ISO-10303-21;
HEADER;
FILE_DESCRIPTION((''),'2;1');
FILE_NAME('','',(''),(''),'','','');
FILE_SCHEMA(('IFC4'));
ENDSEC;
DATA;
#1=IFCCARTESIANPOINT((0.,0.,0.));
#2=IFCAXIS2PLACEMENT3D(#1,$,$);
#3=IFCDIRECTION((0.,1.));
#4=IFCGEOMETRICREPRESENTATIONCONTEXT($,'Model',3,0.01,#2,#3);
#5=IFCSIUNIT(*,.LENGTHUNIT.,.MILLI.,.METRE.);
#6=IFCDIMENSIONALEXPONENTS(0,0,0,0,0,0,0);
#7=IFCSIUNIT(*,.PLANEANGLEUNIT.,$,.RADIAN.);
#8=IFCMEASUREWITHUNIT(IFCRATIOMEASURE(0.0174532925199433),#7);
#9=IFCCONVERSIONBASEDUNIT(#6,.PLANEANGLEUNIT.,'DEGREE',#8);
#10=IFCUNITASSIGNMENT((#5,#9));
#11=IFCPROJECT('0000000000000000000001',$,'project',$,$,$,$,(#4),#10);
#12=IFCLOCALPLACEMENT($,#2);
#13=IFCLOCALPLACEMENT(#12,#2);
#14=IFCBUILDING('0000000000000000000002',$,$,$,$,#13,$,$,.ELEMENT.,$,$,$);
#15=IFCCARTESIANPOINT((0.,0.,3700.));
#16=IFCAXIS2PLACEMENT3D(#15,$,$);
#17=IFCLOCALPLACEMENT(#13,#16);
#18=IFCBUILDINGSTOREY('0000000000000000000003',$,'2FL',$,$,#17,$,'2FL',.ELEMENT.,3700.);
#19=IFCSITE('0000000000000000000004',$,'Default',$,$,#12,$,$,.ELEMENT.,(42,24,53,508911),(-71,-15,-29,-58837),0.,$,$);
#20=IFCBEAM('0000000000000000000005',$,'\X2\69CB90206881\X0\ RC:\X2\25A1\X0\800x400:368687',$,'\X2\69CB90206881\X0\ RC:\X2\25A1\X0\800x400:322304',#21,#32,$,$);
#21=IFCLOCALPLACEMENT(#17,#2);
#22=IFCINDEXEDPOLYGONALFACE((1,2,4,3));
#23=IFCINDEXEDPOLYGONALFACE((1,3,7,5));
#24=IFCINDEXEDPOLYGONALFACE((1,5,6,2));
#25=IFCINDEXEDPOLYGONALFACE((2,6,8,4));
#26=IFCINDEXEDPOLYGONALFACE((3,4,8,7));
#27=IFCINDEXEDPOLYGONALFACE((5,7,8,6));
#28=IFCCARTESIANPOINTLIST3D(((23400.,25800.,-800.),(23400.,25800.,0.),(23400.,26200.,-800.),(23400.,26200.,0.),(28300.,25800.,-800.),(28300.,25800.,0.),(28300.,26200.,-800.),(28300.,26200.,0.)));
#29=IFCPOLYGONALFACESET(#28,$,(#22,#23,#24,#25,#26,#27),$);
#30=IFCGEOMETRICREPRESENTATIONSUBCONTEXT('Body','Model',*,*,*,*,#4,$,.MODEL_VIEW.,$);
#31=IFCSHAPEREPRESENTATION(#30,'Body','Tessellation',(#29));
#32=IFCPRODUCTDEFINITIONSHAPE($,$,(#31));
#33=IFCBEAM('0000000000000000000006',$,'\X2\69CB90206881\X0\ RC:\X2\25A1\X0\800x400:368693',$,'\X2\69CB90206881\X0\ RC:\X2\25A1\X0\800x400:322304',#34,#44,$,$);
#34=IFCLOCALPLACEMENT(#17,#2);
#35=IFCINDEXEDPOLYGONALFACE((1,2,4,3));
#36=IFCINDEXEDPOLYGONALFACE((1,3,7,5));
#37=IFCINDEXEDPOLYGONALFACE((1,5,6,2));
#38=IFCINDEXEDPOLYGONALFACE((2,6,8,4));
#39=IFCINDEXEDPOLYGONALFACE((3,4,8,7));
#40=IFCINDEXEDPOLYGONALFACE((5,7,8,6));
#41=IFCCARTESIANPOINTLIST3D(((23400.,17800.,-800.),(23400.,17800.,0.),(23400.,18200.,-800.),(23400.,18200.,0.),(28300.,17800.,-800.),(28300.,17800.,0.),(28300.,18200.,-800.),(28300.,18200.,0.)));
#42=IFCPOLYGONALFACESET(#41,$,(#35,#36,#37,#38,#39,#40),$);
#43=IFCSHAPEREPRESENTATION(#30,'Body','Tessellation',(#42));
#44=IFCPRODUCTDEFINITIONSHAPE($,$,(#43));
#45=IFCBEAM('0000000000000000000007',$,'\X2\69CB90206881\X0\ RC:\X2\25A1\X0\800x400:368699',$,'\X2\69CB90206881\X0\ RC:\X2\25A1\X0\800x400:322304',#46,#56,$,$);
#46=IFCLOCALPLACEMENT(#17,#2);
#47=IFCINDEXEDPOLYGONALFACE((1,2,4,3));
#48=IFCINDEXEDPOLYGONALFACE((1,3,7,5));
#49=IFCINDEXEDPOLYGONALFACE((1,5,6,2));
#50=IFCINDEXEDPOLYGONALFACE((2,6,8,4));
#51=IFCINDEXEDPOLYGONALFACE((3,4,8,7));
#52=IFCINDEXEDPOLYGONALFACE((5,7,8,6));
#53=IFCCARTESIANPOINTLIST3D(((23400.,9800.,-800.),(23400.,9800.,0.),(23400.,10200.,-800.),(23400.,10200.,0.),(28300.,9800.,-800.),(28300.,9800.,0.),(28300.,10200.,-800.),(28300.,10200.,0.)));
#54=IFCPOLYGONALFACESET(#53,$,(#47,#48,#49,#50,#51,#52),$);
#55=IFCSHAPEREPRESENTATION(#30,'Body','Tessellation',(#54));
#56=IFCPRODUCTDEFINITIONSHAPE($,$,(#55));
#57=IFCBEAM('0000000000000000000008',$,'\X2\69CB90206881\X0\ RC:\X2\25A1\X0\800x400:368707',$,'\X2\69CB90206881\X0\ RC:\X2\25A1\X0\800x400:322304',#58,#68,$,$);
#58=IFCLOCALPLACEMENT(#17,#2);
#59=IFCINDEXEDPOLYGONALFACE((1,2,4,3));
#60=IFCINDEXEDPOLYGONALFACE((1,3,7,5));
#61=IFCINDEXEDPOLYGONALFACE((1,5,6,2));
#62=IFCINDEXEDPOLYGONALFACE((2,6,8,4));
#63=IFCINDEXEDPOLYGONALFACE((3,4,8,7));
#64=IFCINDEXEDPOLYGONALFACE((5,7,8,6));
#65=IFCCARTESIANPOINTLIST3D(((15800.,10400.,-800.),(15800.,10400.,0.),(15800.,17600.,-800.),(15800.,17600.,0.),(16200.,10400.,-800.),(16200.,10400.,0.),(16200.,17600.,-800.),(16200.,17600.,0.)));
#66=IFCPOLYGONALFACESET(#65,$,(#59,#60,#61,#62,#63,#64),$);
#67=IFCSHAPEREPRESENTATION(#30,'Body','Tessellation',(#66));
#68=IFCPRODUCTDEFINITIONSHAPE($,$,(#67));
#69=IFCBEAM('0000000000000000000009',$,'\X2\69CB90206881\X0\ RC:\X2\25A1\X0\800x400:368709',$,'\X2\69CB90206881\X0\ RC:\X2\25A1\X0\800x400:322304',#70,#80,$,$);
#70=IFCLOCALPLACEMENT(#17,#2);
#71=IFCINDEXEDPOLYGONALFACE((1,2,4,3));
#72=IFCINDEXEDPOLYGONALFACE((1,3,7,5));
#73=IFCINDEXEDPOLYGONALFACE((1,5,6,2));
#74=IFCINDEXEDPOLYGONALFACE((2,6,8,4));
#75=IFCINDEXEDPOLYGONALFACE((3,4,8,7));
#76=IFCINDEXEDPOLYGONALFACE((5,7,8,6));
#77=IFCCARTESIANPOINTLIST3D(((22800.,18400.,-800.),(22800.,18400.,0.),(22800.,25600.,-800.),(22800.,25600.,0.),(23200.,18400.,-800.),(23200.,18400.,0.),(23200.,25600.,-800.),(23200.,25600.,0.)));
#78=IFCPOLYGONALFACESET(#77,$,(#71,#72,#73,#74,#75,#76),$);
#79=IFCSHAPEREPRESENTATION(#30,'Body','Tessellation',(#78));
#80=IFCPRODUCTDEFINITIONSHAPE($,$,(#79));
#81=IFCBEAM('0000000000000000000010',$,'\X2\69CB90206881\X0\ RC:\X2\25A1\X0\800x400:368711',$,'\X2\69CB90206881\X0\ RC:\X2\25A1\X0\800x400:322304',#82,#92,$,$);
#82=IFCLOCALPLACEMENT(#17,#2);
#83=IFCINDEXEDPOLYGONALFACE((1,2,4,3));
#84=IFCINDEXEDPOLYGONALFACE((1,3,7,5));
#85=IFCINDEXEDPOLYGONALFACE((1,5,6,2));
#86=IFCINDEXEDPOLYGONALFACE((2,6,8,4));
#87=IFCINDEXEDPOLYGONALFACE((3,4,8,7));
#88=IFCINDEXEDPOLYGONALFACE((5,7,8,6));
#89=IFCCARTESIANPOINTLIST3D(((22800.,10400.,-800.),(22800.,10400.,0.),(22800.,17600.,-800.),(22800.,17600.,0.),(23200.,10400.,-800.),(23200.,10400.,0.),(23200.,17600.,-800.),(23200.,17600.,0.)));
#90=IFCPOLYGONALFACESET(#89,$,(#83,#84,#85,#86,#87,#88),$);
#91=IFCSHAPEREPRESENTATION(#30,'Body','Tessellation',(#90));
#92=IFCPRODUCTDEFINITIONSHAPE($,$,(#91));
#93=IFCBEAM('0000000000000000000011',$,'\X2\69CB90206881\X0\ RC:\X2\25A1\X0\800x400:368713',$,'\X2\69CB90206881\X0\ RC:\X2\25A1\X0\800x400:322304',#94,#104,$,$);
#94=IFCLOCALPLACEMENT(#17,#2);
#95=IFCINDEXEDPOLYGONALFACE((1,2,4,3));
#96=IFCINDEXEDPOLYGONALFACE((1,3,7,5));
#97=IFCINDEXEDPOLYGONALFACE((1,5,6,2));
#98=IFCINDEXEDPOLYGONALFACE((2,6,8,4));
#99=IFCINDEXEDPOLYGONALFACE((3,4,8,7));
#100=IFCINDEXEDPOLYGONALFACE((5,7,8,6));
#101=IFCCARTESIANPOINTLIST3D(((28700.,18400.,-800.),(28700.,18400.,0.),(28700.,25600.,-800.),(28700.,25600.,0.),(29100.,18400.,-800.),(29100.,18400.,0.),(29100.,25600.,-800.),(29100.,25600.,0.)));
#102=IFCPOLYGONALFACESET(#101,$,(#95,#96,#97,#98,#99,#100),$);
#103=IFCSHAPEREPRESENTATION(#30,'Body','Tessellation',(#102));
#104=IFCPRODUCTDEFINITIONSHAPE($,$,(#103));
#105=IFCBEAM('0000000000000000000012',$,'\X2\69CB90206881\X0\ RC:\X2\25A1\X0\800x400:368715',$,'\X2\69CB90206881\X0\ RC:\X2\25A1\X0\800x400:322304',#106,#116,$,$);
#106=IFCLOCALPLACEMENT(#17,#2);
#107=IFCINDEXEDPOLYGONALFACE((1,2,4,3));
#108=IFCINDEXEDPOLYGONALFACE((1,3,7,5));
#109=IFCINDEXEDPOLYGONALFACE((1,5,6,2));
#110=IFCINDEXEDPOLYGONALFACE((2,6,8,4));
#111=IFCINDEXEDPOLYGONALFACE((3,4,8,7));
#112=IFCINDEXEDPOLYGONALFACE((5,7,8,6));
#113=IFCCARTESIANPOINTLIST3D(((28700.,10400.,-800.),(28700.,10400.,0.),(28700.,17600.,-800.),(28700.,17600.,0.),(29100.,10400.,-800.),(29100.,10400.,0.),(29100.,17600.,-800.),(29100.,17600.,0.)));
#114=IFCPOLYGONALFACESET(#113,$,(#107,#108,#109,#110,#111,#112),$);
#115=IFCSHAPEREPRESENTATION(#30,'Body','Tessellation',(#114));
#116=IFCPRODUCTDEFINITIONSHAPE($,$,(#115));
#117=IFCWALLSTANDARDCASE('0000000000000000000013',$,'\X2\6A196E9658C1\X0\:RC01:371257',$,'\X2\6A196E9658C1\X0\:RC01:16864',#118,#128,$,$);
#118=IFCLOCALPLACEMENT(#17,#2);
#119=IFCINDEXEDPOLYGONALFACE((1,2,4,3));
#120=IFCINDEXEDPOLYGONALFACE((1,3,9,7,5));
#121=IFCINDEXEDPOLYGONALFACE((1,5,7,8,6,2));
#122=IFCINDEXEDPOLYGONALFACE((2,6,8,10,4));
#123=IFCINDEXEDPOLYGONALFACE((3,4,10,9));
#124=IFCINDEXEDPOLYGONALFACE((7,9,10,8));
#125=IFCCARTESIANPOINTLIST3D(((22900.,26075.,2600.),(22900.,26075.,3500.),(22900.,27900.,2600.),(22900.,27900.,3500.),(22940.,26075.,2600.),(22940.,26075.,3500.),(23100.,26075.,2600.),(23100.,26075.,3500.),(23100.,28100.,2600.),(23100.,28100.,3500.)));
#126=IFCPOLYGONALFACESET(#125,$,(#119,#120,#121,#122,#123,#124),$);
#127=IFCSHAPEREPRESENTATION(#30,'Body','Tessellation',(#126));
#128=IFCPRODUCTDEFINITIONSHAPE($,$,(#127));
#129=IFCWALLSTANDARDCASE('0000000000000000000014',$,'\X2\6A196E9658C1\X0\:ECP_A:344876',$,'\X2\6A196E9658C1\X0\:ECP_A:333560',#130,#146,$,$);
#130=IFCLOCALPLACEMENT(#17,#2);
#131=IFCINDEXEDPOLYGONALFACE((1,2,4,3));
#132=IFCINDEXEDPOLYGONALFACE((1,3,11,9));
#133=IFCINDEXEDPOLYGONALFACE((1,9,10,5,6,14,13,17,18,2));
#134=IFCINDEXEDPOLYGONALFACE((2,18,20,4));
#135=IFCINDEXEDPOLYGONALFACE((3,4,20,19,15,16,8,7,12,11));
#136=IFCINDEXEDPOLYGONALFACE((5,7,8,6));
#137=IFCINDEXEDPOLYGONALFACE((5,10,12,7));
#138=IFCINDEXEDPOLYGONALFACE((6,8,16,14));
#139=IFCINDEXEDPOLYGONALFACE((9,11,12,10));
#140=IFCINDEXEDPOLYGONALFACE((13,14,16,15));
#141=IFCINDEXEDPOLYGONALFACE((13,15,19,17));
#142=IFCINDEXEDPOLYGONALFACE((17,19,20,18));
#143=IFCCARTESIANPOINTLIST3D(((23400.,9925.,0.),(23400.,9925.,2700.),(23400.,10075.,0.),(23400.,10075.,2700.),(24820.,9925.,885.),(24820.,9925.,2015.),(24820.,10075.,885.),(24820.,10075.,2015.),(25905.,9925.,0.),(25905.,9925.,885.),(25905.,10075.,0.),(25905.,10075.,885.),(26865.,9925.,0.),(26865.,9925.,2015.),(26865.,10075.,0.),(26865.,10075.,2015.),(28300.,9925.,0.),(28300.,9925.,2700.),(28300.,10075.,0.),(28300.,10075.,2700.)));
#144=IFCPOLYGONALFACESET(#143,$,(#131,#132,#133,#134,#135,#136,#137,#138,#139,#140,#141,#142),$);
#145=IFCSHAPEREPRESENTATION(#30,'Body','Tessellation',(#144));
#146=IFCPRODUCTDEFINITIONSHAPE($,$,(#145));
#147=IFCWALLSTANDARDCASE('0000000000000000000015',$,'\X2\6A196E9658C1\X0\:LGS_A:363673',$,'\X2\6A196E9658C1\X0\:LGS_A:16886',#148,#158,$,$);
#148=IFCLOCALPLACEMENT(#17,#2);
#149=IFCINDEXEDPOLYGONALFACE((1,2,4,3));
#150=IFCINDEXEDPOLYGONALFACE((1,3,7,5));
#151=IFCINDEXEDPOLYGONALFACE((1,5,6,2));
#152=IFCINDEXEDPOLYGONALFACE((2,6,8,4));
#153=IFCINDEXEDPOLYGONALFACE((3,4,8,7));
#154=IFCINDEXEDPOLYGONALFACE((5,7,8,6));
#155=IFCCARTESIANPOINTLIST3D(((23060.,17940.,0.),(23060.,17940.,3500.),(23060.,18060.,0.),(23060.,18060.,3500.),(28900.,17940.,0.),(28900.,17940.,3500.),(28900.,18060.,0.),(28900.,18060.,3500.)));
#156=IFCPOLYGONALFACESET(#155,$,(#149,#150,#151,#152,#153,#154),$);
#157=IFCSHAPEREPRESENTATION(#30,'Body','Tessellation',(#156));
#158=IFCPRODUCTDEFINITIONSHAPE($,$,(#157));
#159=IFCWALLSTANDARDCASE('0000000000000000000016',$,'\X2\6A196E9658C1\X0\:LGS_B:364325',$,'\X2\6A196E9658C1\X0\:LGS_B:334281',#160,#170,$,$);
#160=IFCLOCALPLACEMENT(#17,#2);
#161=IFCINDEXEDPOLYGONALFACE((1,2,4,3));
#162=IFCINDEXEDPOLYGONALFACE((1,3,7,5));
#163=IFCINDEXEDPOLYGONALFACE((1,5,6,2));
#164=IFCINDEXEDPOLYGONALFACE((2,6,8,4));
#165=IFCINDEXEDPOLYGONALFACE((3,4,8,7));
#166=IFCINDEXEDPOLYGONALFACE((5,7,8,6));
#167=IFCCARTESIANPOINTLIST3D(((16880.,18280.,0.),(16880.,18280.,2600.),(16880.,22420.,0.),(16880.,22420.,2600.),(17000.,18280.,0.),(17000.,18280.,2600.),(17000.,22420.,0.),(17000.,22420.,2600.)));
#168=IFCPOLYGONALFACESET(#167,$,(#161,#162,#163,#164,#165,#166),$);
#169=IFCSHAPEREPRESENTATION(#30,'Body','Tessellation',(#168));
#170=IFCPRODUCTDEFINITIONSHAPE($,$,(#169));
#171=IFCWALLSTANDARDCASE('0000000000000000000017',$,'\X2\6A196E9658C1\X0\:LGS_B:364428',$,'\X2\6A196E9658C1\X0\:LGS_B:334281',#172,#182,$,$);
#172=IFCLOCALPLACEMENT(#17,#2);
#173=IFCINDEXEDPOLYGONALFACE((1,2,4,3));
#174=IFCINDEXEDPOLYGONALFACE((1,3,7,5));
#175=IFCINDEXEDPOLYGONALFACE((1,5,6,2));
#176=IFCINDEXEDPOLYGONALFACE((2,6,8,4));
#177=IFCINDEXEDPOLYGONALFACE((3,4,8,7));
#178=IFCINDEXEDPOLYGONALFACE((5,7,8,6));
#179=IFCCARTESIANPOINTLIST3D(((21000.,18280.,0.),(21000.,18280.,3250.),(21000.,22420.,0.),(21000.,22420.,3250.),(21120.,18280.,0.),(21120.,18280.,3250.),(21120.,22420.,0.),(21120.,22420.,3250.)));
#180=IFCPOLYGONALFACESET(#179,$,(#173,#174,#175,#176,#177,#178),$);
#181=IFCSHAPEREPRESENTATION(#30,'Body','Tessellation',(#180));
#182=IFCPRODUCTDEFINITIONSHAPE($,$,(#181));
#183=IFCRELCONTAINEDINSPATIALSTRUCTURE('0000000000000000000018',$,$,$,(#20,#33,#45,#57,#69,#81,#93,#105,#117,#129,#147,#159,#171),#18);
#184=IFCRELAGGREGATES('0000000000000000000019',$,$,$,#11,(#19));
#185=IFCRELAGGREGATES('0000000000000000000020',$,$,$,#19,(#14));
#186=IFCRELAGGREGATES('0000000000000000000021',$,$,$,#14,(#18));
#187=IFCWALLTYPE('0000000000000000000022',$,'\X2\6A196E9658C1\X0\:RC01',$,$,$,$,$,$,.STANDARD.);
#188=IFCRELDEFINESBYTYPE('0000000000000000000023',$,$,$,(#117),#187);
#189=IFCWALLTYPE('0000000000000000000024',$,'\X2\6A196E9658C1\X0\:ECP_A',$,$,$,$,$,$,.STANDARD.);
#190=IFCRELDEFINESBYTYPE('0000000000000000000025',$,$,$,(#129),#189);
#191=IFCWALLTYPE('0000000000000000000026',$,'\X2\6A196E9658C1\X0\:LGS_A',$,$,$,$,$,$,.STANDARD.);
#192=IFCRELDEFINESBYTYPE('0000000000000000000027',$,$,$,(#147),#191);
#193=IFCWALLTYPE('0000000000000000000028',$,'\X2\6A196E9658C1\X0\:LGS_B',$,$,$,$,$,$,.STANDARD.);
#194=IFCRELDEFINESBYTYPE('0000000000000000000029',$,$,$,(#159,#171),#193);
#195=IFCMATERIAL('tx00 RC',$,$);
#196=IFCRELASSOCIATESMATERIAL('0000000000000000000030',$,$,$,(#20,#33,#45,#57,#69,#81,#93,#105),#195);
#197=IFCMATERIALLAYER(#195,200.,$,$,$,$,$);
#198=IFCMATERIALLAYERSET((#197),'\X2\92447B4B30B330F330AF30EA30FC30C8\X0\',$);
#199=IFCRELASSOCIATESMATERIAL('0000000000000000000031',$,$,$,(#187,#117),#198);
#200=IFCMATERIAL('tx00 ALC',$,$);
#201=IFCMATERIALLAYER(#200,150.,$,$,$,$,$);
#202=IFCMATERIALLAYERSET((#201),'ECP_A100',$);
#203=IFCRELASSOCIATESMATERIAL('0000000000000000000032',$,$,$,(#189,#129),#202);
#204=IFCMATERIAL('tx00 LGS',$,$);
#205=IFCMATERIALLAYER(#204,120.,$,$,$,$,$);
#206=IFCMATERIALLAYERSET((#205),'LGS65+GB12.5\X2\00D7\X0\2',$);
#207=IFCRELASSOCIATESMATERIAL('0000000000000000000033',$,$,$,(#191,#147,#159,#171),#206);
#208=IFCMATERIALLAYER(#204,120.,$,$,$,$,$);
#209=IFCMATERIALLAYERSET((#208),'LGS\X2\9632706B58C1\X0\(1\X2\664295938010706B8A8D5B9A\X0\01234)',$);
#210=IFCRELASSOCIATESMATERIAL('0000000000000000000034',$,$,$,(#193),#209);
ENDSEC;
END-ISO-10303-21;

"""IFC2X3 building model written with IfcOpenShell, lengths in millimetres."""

from ifc_helpers import new_model, entity, si_unit, converted_unit, direction, frame, frame_2d, origin, place, context, subcontext, project, spatial, polyline, rectangle, outline, extrude, material, layer, layer_set, layer_usage, type_object, element, save


model = new_model("IFC2X3")

# Units and contexts
model_context = context("Model", 3, precision=0.01, world=origin(), true_north=direction((0.0, 1.0)))
body_context = subcontext(model_context, "Body", "Model", "MODEL_VIEW")
ifc_project = project(units=[si_unit("LENGTHUNIT", "METRE", prefix="MILLI"), converted_unit("PLANEANGLEUNIT", "DEGREE", entity("IfcRatioMeasure", 0.0174532925199433), si_unit("PLANEANGLEUNIT", "RADIAN"), dimensions=[0, 0, 0, 0, 0, 0, 0])], contexts=[model_context])

# Site, building, storey
site_placement = place(None, origin())
site = spatial("IfcSite", under=ifc_project, at=site_placement, Name="Default", CompositionType="ELEMENT", RefLatitude=(42, 24, 53, 508911), RefLongitude=(-71, -15, -29, -58837), RefElevation=0.0)
building_placement = place(site_placement, origin())
building = spatial("IfcBuilding", under=site, at=building_placement, CompositionType="ELEMENT")
storey_placement = place(building_placement, frame((0.0, 0.0, 3700.0)))
storey = spatial("IfcBuildingStorey", under=building, at=storey_placement, Name="2FL", LongName="2FL", CompositionType="ELEMENT", Elevation=3700.0)

# Beams
ifc_material_1 = material(Name="tx00 RC")
beam_1_placement = place(storey_placement, frame((23000.0, 26000.0, 0.0)))
element("IfcBeam", 1, at=beam_1_placement, inside=storey, material=ifc_material_1, Name="構造梁 RC:□800x400:368687", ObjectType="構造梁 RC:□800x400:322304", context=body_context, shape_type="SweptSolid", body=[
    extrude(rectangle(XDim=800.0, YDim=400.0, at=frame_2d((0.0, 0.0), x_axis=(1.0, 0.0))), frame((400.0, 0.0, -400.0), z_axis=(1.0, 0.0, 0.0), x_axis=(0.0, 0.0, -1.0)), (0.0, 0.0, 1.0), 4900.0),
])
beam_2_placement = place(storey_placement, frame((23000.0, 18000.0, 0.0)))
element("IfcBeam", 2, at=beam_2_placement, inside=storey, material=ifc_material_1, Name="構造梁 RC:□800x400:368693", ObjectType="構造梁 RC:□800x400:322304", context=body_context, shape_type="SweptSolid", body=[
    extrude(rectangle(XDim=800.0, YDim=400.0, at=frame_2d((0.0, 0.0), x_axis=(1.0, 0.0))), frame((400.0, 0.0, -400.0), z_axis=(1.0, 0.0, 0.0), x_axis=(0.0, 0.0, -1.0)), (0.0, 0.0, 1.0), 4900.0),
])
beam_3_placement = place(storey_placement, frame((23000.0, 10000.0, 0.0)))
element("IfcBeam", 3, at=beam_3_placement, inside=storey, material=ifc_material_1, Name="構造梁 RC:□800x400:368699", ObjectType="構造梁 RC:□800x400:322304", context=body_context, shape_type="SweptSolid", body=[
    extrude(rectangle(XDim=800.0, YDim=400.0, at=frame_2d((0.0, 0.0), x_axis=(1.0, 0.0))), frame((400.0, 0.0, -400.0), z_axis=(1.0, 0.0, 0.0), x_axis=(0.0, 0.0, -1.0)), (0.0, 0.0, 1.0), 4900.0),
])
beam_4_placement = place(storey_placement, frame((16000.0, 18000.0, 0.0), z_axis=(0.0, 0.0, 1.0), x_axis=(0.0, -1.0, 0.0)))
element("IfcBeam", 4, at=beam_4_placement, inside=storey, material=ifc_material_1, Name="構造梁 RC:□800x400:368707", ObjectType="構造梁 RC:□800x400:322304", context=body_context, shape_type="SweptSolid", body=[
    extrude(rectangle(XDim=800.0, YDim=400.0, at=frame_2d((0.0, 0.0), x_axis=(1.0, 0.0))), frame((400.0, 0.0, -400.0), z_axis=(1.0, 0.0, 0.0), x_axis=(0.0, 0.0, -1.0)), (0.0, 0.0, 1.0), 7200.0),
])
beam_5_placement = place(storey_placement, frame((23000.0, 26000.0, 0.0), z_axis=(0.0, 0.0, 1.0), x_axis=(0.0, -1.0, 0.0)))
element("IfcBeam", 5, at=beam_5_placement, inside=storey, material=ifc_material_1, Name="構造梁 RC:□800x400:368709", ObjectType="構造梁 RC:□800x400:322304", context=body_context, shape_type="SweptSolid", body=[
    extrude(rectangle(XDim=800.0, YDim=400.0, at=frame_2d((0.0, 0.0), x_axis=(1.0, 0.0))), frame((400.0, 0.0, -400.0), z_axis=(1.0, 0.0, 0.0), x_axis=(0.0, 0.0, -1.0)), (0.0, 0.0, 1.0), 7200.0),
])
beam_6_placement = place(storey_placement, frame((23000.0, 18000.0, 0.0), z_axis=(0.0, 0.0, 1.0), x_axis=(0.0, -1.0, 0.0)))
element("IfcBeam", 6, at=beam_6_placement, inside=storey, material=ifc_material_1, Name="構造梁 RC:□800x400:368711", ObjectType="構造梁 RC:□800x400:322304", context=body_context, shape_type="SweptSolid", body=[
    extrude(rectangle(XDim=800.0, YDim=400.0, at=frame_2d((0.0, 0.0), x_axis=(1.0, 0.0))), frame((400.0, 0.0, -400.0), z_axis=(1.0, 0.0, 0.0), x_axis=(0.0, 0.0, -1.0)), (0.0, 0.0, 1.0), 7200.0),
])
beam_7_placement = place(storey_placement, frame((28900.0, 26000.0, 0.0), z_axis=(0.0, 0.0, 1.0), x_axis=(0.0, -1.0, 0.0)))
element("IfcBeam", 7, at=beam_7_placement, inside=storey, material=ifc_material_1, Name="構造梁 RC:□800x400:368713", ObjectType="構造梁 RC:□800x400:322304", context=body_context, shape_type="SweptSolid", body=[
    extrude(rectangle(XDim=800.0, YDim=400.0, at=frame_2d((0.0, 0.0), x_axis=(1.0, 0.0))), frame((400.0, 0.0, -400.0), z_axis=(1.0, 0.0, 0.0), x_axis=(0.0, 0.0, -1.0)), (0.0, 0.0, 1.0), 7200.0),
])
beam_8_placement = place(storey_placement, frame((28900.0, 18000.0, 0.0), z_axis=(0.0, 0.0, 1.0), x_axis=(0.0, -1.0, 0.0)))
element("IfcBeam", 8, at=beam_8_placement, inside=storey, material=ifc_material_1, Name="構造梁 RC:□800x400:368715", ObjectType="構造梁 RC:□800x400:322304", context=body_context, shape_type="SweptSolid", body=[
    extrude(rectangle(XDim=800.0, YDim=400.0, at=frame_2d((0.0, 0.0), x_axis=(1.0, 0.0))), frame((400.0, 0.0, -400.0), z_axis=(1.0, 0.0, 0.0), x_axis=(0.0, 0.0, -1.0)), (0.0, 0.0, 1.0), 7200.0),
])

# Wall
ifc_layer_1 = layer(ifc_material_1, 200.0)
ifc_layer_set_1 = layer_set([ifc_layer_1], Name="鉄筋コンクリート")
ifc_layer_usage_1 = layer_usage(ifc_layer_set_1, "AXIS2", "NEGATIVE", 100.0)
wall_type_1 = type_object("IfcWallType", Name="標準壁:RC01", PredefinedType="STANDARD", material=ifc_layer_set_1)
wall_1_placement = place(storey_placement, frame((23000.0, 28100.0, 2600.0), z_axis=(0.0, 0.0, 1.0), x_axis=(0.0, -1.0, 0.0)))
element("IfcWallStandardCase", 9, at=wall_1_placement, inside=storey, type_object=wall_type_1, material=ifc_layer_usage_1, Name="標準壁:RC01:371257", ObjectType="標準壁:RC01:16864", context=body_context, shape_type="SweptSolid", body=[
    extrude(outline(polyline([(2025.0, -100.0), (2025.0, -60.0), (2025.0, 100.0), (0.0, 100.0), (200.0, -100.0), (2025.0, -100.0)])), origin(), (0.0, 0.0, 1.0), 900.0),
])

# Wall, opening
ifc_material_2 = material(Name="tx00 ALC")
ifc_layer_2 = layer(ifc_material_2, 150.0)
ifc_layer_set_2 = layer_set([ifc_layer_2], Name="ECP_A100")
ifc_layer_usage_2 = layer_usage(ifc_layer_set_2, "AXIS2", "NEGATIVE", 75.0)
wall_type_2 = type_object("IfcWallType", Name="標準壁:ECP_A", PredefinedType="STANDARD", material=ifc_layer_set_2)
wall_2_placement = place(storey_placement, frame((23400.0, 10000.0, 0.0)))
wall_2 = element("IfcWallStandardCase", 10, at=wall_2_placement, inside=storey, type_object=wall_type_2, material=ifc_layer_usage_2, Name="標準壁:ECP_A:344876", ObjectType="標準壁:ECP_A:333560", context=body_context, shape_type="SweptSolid", body=[
    extrude(rectangle(XDim=4900.0, YDim=150.0, at=frame_2d((2450.0, 0.0), x_axis=(-1.0, 0.0))), origin(), (0.0, 0.0, 1.0), 2700.0),
])
opening_placement = place(wall_2_placement, frame((3465.0, 75.0, 0.0)))
element("IfcOpeningElement", 11, at=opening_placement, cuts=wall_2, ObjectType="Opening", context=body_context, shape_type="SweptSolid", body=[
    extrude(outline(polyline([(0.0, 0.0), (2015.0, 0.0), (2015.0, 2045.0), (885.0, 2045.0), (885.0, 960.0), (0.0, 960.0), (0.0, 0.0)])), frame((0.0, 0.0, 0.0), z_axis=(0.0, -1.0, 0.0), x_axis=(0.0, 0.0, 1.0)), (0.0, 0.0, 1.0), 150.0),
])

# Walls
ifc_material_3 = material(Name="tx00 LGS")
ifc_layer_3 = layer(ifc_material_3, 120.0)
ifc_layer_set_3 = layer_set([ifc_layer_3], Name="LGS65+GB12.5×2")
ifc_layer_usage_3 = layer_usage(ifc_layer_set_3, "AXIS2", "NEGATIVE", 60.0)
wall_type_3 = type_object("IfcWallType", Name="標準壁:LGS_A", PredefinedType="STANDARD", material=ifc_layer_set_3)
wall_3_placement = place(storey_placement, frame((23060.0, 18000.0, 0.0)))
element("IfcWallStandardCase", 12, at=wall_3_placement, inside=storey, type_object=wall_type_3, material=ifc_layer_usage_3, Name="標準壁:LGS_A:363673", ObjectType="標準壁:LGS_A:16886", context=body_context, shape_type="SweptSolid", body=[
    extrude(rectangle(XDim=5840.0, YDim=120.0, at=frame_2d((2920.0, 0.0), x_axis=(-1.0, 0.0))), origin(), (0.0, 0.0, 1.0), 3500.0),
])
ifc_layer_usage_4 = layer_usage(ifc_layer_set_3, "AXIS2", "POSITIVE", -60.0)
ifc_layer_4 = layer(ifc_material_3, 120.0)
ifc_layer_set_4 = layer_set([ifc_layer_4], Name="LGS防火壁(1時間耐火認定01234)")
wall_type_4 = type_object("IfcWallType", Name="標準壁:LGS_B", PredefinedType="STANDARD", material=ifc_layer_set_4)
wall_4_placement = place(storey_placement, frame((16940.0, 18280.0, 0.0), z_axis=(0.0, 0.0, 1.0), x_axis=(0.0, 1.0, 0.0)))
element("IfcWallStandardCase", 13, at=wall_4_placement, inside=storey, type_object=wall_type_4, material=ifc_layer_usage_4, Name="標準壁:LGS_B:364325", ObjectType="標準壁:LGS_B:334281", context=body_context, shape_type="SweptSolid", body=[
    extrude(rectangle(XDim=4140.0, YDim=120.0, at=frame_2d((2070.0, 0.0), x_axis=(-1.0, 0.0))), origin(), (0.0, 0.0, 1.0), 2600.0),
])
ifc_layer_usage_5 = layer_usage(ifc_layer_set_3, "AXIS2", "NEGATIVE", 60.0)
wall_5_placement = place(storey_placement, frame((21060.0, 18280.0, 0.0), z_axis=(0.0, 0.0, 1.0), x_axis=(0.0, 1.0, 0.0)))
element("IfcWallStandardCase", 14, at=wall_5_placement, inside=storey, type_object=wall_type_4, material=ifc_layer_usage_5, Name="標準壁:LGS_B:364428", ObjectType="標準壁:LGS_B:334281", context=body_context, shape_type="SweptSolid", body=[
    extrude(rectangle(XDim=4140.0, YDim=120.0, at=frame_2d((2070.0, 0.0), x_axis=(-1.0, 0.0))), origin(), (0.0, 0.0, 1.0), 3250.0),
])

save(model, "model.ifc")
